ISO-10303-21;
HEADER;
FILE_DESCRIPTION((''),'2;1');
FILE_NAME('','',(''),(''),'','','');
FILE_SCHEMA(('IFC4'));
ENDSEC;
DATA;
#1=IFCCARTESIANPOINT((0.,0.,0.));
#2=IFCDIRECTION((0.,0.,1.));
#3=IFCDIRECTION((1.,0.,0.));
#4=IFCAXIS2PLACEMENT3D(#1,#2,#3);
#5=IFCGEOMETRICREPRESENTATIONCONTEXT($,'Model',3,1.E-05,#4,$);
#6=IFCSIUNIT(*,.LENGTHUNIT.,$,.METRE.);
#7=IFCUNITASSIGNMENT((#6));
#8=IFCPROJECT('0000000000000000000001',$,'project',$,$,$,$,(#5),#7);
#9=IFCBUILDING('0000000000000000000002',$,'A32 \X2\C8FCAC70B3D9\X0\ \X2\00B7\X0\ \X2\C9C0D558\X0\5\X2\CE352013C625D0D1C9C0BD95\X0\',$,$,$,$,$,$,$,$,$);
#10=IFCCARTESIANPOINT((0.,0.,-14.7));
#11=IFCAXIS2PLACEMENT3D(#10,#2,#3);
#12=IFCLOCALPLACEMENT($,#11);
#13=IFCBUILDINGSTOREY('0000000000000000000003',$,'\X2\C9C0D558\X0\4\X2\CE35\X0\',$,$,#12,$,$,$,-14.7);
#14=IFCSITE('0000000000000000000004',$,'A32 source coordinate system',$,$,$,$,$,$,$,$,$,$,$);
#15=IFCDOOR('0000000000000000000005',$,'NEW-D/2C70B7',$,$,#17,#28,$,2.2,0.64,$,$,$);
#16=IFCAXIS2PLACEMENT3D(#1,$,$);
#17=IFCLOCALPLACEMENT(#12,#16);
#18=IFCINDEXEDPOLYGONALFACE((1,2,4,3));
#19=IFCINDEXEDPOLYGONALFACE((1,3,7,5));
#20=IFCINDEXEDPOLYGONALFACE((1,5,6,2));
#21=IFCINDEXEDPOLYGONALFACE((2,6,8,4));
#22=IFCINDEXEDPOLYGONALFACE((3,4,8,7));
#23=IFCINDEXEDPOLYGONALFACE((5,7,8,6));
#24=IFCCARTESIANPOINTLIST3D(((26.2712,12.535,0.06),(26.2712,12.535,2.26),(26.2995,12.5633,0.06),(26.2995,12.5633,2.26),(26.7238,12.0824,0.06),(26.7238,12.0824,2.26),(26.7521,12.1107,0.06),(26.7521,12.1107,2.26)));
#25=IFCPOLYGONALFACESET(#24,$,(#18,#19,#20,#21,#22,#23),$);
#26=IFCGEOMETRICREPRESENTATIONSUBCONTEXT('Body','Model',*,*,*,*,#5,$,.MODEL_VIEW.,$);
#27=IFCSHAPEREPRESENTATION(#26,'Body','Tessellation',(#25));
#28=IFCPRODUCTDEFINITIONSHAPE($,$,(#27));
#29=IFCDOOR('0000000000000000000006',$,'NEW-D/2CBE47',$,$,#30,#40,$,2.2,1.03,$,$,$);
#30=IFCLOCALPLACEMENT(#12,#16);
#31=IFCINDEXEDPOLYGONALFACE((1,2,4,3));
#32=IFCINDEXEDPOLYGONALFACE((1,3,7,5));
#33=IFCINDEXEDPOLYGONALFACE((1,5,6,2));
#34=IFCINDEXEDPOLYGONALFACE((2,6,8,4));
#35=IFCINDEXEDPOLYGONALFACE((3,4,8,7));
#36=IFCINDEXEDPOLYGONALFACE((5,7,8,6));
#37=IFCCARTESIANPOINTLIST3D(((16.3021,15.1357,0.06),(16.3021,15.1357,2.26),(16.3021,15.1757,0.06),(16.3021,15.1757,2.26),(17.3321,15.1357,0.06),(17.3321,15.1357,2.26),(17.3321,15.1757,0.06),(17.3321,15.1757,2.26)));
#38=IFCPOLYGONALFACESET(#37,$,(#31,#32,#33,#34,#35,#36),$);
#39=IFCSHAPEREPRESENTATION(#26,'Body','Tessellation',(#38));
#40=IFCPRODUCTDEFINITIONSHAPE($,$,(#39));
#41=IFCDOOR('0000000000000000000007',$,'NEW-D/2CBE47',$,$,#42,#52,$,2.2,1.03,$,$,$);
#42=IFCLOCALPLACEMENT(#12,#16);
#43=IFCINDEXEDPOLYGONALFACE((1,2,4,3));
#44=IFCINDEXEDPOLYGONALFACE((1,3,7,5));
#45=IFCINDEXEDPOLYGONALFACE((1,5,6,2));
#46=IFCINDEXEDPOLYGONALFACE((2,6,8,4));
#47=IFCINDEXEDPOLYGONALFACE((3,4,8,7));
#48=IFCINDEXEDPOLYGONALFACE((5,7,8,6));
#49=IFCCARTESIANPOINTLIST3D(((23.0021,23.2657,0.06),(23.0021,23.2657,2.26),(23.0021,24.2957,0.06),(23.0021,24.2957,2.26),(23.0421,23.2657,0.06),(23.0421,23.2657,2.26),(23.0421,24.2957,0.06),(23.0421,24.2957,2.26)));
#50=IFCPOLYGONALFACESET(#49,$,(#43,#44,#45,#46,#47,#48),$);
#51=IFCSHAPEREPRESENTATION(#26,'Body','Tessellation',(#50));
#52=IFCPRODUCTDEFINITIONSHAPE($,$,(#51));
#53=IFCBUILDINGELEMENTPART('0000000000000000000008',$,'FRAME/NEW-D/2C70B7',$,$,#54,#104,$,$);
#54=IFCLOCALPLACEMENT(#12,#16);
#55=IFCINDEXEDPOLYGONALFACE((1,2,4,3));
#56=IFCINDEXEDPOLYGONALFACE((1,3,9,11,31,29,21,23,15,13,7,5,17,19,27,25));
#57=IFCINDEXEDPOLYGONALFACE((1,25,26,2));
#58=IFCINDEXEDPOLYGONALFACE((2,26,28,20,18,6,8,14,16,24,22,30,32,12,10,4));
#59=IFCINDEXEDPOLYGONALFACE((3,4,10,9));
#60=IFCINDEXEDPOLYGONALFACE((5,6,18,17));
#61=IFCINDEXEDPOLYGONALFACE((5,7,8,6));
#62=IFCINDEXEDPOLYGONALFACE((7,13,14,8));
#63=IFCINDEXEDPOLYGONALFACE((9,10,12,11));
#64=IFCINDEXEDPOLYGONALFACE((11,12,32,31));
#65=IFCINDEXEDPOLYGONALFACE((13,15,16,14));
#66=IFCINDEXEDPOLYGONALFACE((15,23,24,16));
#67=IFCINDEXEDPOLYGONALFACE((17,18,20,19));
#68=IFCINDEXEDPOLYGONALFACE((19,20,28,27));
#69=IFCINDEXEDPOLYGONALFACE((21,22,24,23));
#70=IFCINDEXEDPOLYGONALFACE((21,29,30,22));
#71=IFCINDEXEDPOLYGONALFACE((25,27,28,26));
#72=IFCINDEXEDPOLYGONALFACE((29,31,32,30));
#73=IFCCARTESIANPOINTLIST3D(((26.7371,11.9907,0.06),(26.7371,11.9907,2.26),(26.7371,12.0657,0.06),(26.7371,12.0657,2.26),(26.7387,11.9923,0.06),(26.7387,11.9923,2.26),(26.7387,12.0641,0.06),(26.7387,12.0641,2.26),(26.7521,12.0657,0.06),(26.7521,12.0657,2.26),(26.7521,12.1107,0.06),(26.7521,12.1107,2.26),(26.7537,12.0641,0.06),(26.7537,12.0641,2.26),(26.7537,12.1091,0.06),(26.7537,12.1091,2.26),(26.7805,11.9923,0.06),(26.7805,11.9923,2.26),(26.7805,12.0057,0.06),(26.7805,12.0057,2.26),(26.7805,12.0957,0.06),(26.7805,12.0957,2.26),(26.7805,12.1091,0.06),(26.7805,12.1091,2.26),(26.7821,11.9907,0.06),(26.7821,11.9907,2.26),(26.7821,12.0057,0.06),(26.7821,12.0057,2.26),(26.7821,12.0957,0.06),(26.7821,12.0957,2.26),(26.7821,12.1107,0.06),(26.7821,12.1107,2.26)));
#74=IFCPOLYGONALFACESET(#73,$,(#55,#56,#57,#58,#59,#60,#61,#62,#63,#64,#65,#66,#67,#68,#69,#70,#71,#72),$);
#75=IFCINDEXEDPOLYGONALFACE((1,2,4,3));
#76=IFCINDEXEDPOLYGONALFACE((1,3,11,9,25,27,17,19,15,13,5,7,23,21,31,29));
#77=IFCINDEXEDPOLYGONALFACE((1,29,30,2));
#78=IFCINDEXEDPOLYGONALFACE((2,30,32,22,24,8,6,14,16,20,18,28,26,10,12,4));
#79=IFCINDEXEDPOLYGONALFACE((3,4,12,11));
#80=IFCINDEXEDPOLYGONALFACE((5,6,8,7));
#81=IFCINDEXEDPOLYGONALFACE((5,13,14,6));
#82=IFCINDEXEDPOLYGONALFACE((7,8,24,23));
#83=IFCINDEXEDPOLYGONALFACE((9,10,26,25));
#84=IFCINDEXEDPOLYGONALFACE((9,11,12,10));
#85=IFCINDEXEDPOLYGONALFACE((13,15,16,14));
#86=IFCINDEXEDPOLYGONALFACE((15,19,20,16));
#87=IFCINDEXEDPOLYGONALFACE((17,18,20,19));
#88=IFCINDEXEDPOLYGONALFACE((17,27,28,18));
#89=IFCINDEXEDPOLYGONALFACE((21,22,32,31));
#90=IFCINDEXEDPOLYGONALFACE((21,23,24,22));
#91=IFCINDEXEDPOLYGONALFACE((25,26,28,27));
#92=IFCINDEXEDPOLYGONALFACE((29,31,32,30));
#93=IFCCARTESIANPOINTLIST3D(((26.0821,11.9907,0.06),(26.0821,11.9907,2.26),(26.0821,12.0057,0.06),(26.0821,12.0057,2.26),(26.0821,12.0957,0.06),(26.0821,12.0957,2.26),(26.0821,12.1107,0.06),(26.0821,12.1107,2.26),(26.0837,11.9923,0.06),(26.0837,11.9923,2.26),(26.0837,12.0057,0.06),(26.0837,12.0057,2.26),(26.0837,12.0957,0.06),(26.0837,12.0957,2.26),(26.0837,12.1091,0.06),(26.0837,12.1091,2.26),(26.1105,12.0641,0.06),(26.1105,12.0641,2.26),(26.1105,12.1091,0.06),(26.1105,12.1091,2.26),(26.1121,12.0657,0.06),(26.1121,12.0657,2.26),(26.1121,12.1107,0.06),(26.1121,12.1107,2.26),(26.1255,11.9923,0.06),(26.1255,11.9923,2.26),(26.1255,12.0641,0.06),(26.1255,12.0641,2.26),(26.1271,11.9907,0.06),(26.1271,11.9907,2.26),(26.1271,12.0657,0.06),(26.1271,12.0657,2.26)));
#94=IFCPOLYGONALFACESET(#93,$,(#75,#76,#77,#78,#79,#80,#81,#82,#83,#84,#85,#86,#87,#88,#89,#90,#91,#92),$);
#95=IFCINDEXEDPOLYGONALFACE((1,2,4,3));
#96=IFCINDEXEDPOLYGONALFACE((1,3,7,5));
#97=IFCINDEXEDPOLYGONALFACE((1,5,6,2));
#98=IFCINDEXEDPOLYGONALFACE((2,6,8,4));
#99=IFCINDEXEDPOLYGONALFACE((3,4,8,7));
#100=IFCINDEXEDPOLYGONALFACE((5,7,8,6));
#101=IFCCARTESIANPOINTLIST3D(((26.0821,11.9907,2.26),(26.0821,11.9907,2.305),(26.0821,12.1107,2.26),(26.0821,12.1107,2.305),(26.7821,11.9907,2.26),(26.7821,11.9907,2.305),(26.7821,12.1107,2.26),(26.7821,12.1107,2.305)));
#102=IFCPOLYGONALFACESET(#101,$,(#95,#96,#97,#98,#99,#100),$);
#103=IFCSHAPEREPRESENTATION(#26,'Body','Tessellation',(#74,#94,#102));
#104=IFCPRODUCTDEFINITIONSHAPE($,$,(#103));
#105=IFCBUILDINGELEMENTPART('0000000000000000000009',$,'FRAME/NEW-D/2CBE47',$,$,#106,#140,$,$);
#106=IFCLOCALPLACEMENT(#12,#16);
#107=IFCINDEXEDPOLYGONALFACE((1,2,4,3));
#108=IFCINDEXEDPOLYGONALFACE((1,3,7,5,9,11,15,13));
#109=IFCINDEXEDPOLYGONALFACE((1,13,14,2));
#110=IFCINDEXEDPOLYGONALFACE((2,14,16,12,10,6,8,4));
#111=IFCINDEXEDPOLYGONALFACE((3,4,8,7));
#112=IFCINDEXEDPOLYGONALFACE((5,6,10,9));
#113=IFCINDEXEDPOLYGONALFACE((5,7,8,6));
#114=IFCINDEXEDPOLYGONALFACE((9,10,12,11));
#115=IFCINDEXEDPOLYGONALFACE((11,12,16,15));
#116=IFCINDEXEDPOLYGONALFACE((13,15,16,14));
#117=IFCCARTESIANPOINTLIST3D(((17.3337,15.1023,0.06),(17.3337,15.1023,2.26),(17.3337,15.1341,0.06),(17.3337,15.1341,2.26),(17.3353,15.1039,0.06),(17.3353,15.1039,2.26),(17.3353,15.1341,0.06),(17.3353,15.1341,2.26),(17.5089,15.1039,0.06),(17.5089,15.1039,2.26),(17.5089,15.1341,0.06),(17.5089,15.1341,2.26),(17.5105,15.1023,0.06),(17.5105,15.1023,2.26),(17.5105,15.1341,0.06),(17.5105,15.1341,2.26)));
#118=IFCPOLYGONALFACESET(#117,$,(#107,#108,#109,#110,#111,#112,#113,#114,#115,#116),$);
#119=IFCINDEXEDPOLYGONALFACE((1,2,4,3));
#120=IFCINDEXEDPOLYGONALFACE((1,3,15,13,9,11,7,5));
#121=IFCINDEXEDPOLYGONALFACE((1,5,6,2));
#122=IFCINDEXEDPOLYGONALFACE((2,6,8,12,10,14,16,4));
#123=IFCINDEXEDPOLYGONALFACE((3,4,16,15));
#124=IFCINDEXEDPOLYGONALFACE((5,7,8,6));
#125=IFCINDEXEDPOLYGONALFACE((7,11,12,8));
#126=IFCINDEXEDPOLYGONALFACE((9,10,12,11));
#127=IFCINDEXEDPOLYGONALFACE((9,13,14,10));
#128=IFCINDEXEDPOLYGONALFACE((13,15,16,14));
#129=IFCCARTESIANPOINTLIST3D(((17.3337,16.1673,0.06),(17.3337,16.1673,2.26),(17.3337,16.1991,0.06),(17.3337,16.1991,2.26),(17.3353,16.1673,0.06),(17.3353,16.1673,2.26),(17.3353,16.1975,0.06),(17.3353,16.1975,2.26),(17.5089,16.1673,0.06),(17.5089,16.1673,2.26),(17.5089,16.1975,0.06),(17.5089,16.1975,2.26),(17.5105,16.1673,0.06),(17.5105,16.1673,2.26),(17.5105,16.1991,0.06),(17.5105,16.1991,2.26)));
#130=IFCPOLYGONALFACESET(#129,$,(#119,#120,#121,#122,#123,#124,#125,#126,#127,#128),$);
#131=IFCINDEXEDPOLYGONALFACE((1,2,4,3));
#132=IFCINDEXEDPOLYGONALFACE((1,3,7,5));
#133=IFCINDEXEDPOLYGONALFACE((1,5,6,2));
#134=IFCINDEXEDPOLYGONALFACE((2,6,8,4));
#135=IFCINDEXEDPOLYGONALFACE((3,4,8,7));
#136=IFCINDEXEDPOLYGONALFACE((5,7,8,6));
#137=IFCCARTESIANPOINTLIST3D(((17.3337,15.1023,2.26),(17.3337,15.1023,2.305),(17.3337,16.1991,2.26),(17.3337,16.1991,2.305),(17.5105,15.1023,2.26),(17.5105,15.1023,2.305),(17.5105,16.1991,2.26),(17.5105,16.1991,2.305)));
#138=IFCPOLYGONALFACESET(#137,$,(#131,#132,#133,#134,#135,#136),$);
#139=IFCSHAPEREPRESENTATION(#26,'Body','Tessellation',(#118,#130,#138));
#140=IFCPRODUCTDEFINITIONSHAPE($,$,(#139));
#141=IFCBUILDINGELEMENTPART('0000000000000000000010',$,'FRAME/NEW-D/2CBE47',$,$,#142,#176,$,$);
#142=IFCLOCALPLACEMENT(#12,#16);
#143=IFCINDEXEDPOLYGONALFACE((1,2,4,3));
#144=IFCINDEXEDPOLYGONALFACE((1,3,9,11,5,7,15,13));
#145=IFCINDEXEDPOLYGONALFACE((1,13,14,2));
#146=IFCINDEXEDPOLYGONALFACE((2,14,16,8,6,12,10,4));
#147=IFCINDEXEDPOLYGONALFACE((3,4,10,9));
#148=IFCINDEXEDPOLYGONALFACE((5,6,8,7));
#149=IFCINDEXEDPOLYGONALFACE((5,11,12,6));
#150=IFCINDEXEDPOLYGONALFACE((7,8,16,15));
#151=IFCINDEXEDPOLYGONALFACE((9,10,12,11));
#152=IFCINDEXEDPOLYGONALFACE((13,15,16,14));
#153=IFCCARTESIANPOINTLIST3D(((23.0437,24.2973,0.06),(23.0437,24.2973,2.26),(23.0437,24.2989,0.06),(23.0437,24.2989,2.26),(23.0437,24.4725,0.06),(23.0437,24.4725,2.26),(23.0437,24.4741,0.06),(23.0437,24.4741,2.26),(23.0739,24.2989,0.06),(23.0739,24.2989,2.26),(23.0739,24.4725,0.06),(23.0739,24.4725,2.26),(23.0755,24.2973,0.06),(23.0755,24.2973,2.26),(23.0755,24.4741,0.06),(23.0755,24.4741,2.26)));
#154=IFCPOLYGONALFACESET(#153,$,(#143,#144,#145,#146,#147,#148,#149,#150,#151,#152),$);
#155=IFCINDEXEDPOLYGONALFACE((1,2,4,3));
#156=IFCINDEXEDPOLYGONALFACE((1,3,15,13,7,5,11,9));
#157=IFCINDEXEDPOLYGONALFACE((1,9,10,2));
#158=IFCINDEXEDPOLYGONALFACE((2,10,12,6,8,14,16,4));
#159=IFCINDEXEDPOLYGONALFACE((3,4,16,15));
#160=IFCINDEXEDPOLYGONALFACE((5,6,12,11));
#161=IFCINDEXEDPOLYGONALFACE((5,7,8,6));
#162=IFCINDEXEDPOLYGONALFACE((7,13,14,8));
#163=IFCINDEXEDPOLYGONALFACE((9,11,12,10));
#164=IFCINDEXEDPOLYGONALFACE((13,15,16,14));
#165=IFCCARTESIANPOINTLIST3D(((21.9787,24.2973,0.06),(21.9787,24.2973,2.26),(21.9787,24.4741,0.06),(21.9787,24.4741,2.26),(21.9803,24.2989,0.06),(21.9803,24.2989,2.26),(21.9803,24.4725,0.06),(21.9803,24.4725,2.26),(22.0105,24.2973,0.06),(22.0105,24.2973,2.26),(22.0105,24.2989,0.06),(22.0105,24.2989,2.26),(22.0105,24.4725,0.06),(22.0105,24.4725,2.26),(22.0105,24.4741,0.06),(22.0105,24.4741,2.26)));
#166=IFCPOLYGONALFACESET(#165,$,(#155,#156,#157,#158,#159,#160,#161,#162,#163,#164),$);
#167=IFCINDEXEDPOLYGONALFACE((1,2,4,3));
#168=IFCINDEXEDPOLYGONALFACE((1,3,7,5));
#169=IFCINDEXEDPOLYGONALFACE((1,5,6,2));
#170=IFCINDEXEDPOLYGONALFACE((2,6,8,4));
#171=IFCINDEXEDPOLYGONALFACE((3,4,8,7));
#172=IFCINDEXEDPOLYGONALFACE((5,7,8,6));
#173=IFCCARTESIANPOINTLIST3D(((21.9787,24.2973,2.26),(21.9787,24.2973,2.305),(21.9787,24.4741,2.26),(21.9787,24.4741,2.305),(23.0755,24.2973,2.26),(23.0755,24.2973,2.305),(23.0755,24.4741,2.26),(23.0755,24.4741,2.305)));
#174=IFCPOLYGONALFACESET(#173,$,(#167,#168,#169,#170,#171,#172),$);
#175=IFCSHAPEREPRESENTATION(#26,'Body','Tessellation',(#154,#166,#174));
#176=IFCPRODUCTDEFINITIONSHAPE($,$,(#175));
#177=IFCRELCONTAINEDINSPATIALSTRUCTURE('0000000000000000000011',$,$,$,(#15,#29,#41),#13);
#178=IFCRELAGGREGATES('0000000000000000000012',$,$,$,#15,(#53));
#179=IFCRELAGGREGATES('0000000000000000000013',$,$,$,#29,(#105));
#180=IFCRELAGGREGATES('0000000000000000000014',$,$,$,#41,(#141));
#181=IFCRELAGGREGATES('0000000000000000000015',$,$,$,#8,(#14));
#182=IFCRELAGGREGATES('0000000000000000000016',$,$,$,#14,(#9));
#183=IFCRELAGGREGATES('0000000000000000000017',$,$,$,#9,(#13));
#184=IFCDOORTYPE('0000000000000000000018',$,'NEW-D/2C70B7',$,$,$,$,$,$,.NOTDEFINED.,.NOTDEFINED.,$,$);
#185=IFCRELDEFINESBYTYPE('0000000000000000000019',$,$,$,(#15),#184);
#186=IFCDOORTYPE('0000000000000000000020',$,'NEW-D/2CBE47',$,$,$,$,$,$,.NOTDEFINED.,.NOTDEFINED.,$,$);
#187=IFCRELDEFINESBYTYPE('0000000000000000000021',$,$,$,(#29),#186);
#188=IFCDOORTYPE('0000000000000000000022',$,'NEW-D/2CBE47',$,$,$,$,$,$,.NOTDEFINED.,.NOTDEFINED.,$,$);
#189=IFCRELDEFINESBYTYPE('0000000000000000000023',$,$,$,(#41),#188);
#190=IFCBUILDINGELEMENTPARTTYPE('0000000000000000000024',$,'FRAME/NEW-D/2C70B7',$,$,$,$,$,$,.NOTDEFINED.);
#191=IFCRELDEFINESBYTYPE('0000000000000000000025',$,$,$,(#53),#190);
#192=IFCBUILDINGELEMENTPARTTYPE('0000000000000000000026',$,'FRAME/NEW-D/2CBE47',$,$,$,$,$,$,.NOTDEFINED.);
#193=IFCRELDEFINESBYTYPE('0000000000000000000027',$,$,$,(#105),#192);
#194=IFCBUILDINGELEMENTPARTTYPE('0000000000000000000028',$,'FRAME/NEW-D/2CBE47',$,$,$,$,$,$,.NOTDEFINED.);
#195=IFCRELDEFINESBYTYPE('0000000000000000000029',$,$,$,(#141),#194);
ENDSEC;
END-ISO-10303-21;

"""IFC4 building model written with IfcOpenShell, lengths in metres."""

from ifc_helpers import new_model, si_unit, frame, origin, origin_with_axes, place, context, subcontext, project, spatial, polyline, outline, extrude, source, transform, mapped, type_object, type_shapes, element, aggregate, save


model = new_model("IFC4")

# Units and contexts
model_context = context("Model", 3, precision=1e-05, world=origin_with_axes())
body_context = subcontext(model_context, "Body", "Model", "MODEL_VIEW")
ifc_project = project(units=[si_unit("LENGTHUNIT", "METRE")], contexts=[model_context])

# Site, building, storey
site = spatial("IfcSite", under=ifc_project, Name="A32 source coordinate system")
building = spatial("IfcBuilding", under=site, Name="A32 주거동 · 지하5층–옥탑지붕")
storey_placement = place(None, frame((0.0, 0.0, -14.7), z_axis=(0.0, 0.0, 1.0), x_axis=(1.0, 0.0, 0.0)))
storey = spatial("IfcBuildingStorey", under=building, at=storey_placement, Name="지하4층", Elevation=-14.7)

# Doors
door_type_1 = type_object("IfcDoorType", Name="NEW-D/2C70B7", OperationType="NOTDEFINED", PredefinedType="NOTDEFINED")
shared_shape_1 = source(origin(), body_context, "Body", "SweptSolid", [
    extrude(outline(polyline([(26.7521, 12.1107), (26.7238, 12.0824), (26.2712, 12.535), (26.2995, 12.5633), (26.7521, 12.1107)])), frame((0.0, 0.0, 0.06)), (0.0, 0.0, 1.0), 2.2),
])
type_shapes(door_type_1, [shared_shape_1])
door_1_placement = place(storey_placement, origin_with_axes())
door_1 = element("IfcDoor", 1, at=door_1_placement, inside=storey, type_object=door_type_1, Name="NEW-D/2C70B7", OverallHeight=2.2, OverallWidth=0.64, context=body_context, shape_type="MappedRepresentation", body=[
    mapped(shared_shape_1, transform((0.0, 0.0, 0.0), scale=1.0)),
])
door_type_2 = type_object("IfcDoorType", Name="NEW-D/2CBE47", OperationType="NOTDEFINED", PredefinedType="NOTDEFINED")
shared_shape_2 = source(origin(), body_context, "Body", "SweptSolid", [
    extrude(outline(polyline([(16.3021, 15.1757), (17.3321, 15.1757), (17.3321, 15.1357), (16.3021, 15.1357), (16.3021, 15.1757)])), frame((0.0, 0.0, 0.06)), (0.0, 0.0, 1.0), 2.2),
])
type_shapes(door_type_2, [shared_shape_2])
door_2_placement = place(storey_placement, origin_with_axes())
door_2 = element("IfcDoor", 2, at=door_2_placement, inside=storey, type_object=door_type_2, Name="NEW-D/2CBE47", OverallHeight=2.2, OverallWidth=1.03, context=body_context, shape_type="MappedRepresentation", body=[
    mapped(shared_shape_2, transform((0.0, 0.0, 0.0), scale=1.0)),
])
door_type_3 = type_object("IfcDoorType", Name="NEW-D/2CBE47", OperationType="NOTDEFINED", PredefinedType="NOTDEFINED")
shared_shape_3 = source(origin(), body_context, "Body", "SweptSolid", [
    extrude(outline(polyline([(23.0021, 23.2657), (23.0021, 24.2957), (23.0421, 24.2957), (23.0421, 23.2657), (23.0021, 23.2657)])), frame((0.0, 0.0, 0.06)), (0.0, 0.0, 1.0), 2.2),
])
type_shapes(door_type_3, [shared_shape_3])
door_3_placement = place(storey_placement, origin_with_axes())
door_3 = element("IfcDoor", 3, at=door_3_placement, inside=storey, type_object=door_type_3, Name="NEW-D/2CBE47", OverallHeight=2.2, OverallWidth=1.03, context=body_context, shape_type="MappedRepresentation", body=[
    mapped(shared_shape_3, transform((0.0, 0.0, 0.0), scale=1.0)),
])

# Building element parts
building_element_part_type_1 = type_object("IfcBuildingElementPartType", Name="FRAME/NEW-D/2C70B7", PredefinedType="NOTDEFINED")
shared_shape_4 = source(origin(), body_context, "Body", "SweptSolid", [
    extrude(outline(polyline([(26.7537, 12.1091), (26.7537, 12.0641), (26.7387, 12.0641), (26.7387, 11.9923), (26.7805, 11.9923), (26.7805, 12.0057), (26.7821, 12.0057), (26.7821, 11.9907), (26.7371, 11.9907), (26.7371, 12.0657), (26.7521, 12.0657), (26.7521, 12.1107), (26.7821, 12.1107), (26.7821, 12.0957), (26.7805, 12.0957), (26.7805, 12.1091), (26.7537, 12.1091)])), frame((0.0, 0.0, 0.06)), (0.0, 0.0, 1.0), 2.2),
    extrude(outline(polyline([(26.0821, 12.1107), (26.1121, 12.1107), (26.1121, 12.0657), (26.1271, 12.0657), (26.1271, 11.9907), (26.0821, 11.9907), (26.0821, 12.0057), (26.0837, 12.0057), (26.0837, 11.9923), (26.1255, 11.9923), (26.1255, 12.0641), (26.1105, 12.0641), (26.1105, 12.1091), (26.0837, 12.1091), (26.0837, 12.0957), (26.0821, 12.0957), (26.0821, 12.1107)])), frame((0.0, 0.0, 0.06)), (0.0, 0.0, 1.0), 2.2),
    extrude(outline(polyline([(26.7821, 11.9907), (26.7821, 12.1107), (26.0821, 12.1107), (26.0821, 11.9907), (26.7821, 11.9907)])), frame((0.0, 0.0, 2.26)), (0.0, 0.0, 1.0), 0.045),
])
type_shapes(building_element_part_type_1, [shared_shape_4])
building_element_part_1_placement = place(door_1_placement, origin_with_axes())
building_element_part_1 = element("IfcBuildingElementPart", 4, at=building_element_part_1_placement, type_object=building_element_part_type_1, Name="FRAME/NEW-D/2C70B7", context=body_context, shape_type="MappedRepresentation", body=[
    mapped(shared_shape_4, transform((0.0, 0.0, 0.0), scale=1.0)),
])
aggregate(door_1, [building_element_part_1])
building_element_part_type_2 = type_object("IfcBuildingElementPartType", Name="FRAME/NEW-D/2CBE47", PredefinedType="NOTDEFINED")
shared_shape_5 = source(origin(), body_context, "Body", "SweptSolid", [
    extrude(outline(polyline([(17.3353, 15.1039), (17.5089, 15.1039), (17.5089, 15.1341), (17.5105, 15.1341), (17.5105, 15.1023), (17.3337, 15.1023), (17.3337, 15.1341), (17.3353, 15.1341), (17.3353, 15.1039)])), frame((0.0, 0.0, 0.06)), (0.0, 0.0, 1.0), 2.2),
    extrude(outline(polyline([(17.5105, 16.1991), (17.5105, 16.1673), (17.5089, 16.1673), (17.5089, 16.1975), (17.3353, 16.1975), (17.3353, 16.1673), (17.3337, 16.1673), (17.3337, 16.1991), (17.5105, 16.1991)])), frame((0.0, 0.0, 0.06)), (0.0, 0.0, 1.0), 2.2),
    extrude(outline(polyline([(17.5105, 15.1023), (17.5105, 16.1991), (17.3337, 16.1991), (17.3337, 15.1023), (17.5105, 15.1023)])), frame((0.0, 0.0, 2.26)), (0.0, 0.0, 1.0), 0.045),
])
type_shapes(building_element_part_type_2, [shared_shape_5])
building_element_part_2_placement = place(door_2_placement, origin_with_axes())
building_element_part_2 = element("IfcBuildingElementPart", 5, at=building_element_part_2_placement, type_object=building_element_part_type_2, Name="FRAME/NEW-D/2CBE47", context=body_context, shape_type="MappedRepresentation", body=[
    mapped(shared_shape_5, transform((0.0, 0.0, 0.0), scale=1.0)),
])
aggregate(door_2, [building_element_part_2])
building_element_part_type_3 = type_object("IfcBuildingElementPartType", Name="FRAME/NEW-D/2CBE47", PredefinedType="NOTDEFINED")
shared_shape_6 = source(origin(), body_context, "Body", "SweptSolid", [
    extrude(outline(polyline([(23.0739, 24.2989), (23.0739, 24.4725), (23.0437, 24.4725), (23.0437, 24.4741), (23.0755, 24.4741), (23.0755, 24.2973), (23.0437, 24.2973), (23.0437, 24.2989), (23.0739, 24.2989)])), frame((0.0, 0.0, 0.06)), (0.0, 0.0, 1.0), 2.2),
    extrude(outline(polyline([(21.9787, 24.4741), (22.0105, 24.4741), (22.0105, 24.4725), (21.9803, 24.4725), (21.9803, 24.2989), (22.0105, 24.2989), (22.0105, 24.2973), (21.9787, 24.2973), (21.9787, 24.4741)])), frame((0.0, 0.0, 0.06)), (0.0, 0.0, 1.0), 2.2),
    extrude(outline(polyline([(23.0755, 24.2973), (23.0755, 24.4741), (21.9787, 24.4741), (21.9787, 24.2973), (23.0755, 24.2973)])), frame((0.0, 0.0, 2.26)), (0.0, 0.0, 1.0), 0.045),
])
type_shapes(building_element_part_type_3, [shared_shape_6])
building_element_part_3_placement = place(door_3_placement, origin_with_axes())
building_element_part_3 = element("IfcBuildingElementPart", 6, at=building_element_part_3_placement, type_object=building_element_part_type_3, Name="FRAME/NEW-D/2CBE47", context=body_context, shape_type="MappedRepresentation", body=[
    mapped(shared_shape_6, transform((0.0, 0.0, 0.0), scale=1.0)),
])
aggregate(door_3, [building_element_part_3])

save(model, "model.ifc")
